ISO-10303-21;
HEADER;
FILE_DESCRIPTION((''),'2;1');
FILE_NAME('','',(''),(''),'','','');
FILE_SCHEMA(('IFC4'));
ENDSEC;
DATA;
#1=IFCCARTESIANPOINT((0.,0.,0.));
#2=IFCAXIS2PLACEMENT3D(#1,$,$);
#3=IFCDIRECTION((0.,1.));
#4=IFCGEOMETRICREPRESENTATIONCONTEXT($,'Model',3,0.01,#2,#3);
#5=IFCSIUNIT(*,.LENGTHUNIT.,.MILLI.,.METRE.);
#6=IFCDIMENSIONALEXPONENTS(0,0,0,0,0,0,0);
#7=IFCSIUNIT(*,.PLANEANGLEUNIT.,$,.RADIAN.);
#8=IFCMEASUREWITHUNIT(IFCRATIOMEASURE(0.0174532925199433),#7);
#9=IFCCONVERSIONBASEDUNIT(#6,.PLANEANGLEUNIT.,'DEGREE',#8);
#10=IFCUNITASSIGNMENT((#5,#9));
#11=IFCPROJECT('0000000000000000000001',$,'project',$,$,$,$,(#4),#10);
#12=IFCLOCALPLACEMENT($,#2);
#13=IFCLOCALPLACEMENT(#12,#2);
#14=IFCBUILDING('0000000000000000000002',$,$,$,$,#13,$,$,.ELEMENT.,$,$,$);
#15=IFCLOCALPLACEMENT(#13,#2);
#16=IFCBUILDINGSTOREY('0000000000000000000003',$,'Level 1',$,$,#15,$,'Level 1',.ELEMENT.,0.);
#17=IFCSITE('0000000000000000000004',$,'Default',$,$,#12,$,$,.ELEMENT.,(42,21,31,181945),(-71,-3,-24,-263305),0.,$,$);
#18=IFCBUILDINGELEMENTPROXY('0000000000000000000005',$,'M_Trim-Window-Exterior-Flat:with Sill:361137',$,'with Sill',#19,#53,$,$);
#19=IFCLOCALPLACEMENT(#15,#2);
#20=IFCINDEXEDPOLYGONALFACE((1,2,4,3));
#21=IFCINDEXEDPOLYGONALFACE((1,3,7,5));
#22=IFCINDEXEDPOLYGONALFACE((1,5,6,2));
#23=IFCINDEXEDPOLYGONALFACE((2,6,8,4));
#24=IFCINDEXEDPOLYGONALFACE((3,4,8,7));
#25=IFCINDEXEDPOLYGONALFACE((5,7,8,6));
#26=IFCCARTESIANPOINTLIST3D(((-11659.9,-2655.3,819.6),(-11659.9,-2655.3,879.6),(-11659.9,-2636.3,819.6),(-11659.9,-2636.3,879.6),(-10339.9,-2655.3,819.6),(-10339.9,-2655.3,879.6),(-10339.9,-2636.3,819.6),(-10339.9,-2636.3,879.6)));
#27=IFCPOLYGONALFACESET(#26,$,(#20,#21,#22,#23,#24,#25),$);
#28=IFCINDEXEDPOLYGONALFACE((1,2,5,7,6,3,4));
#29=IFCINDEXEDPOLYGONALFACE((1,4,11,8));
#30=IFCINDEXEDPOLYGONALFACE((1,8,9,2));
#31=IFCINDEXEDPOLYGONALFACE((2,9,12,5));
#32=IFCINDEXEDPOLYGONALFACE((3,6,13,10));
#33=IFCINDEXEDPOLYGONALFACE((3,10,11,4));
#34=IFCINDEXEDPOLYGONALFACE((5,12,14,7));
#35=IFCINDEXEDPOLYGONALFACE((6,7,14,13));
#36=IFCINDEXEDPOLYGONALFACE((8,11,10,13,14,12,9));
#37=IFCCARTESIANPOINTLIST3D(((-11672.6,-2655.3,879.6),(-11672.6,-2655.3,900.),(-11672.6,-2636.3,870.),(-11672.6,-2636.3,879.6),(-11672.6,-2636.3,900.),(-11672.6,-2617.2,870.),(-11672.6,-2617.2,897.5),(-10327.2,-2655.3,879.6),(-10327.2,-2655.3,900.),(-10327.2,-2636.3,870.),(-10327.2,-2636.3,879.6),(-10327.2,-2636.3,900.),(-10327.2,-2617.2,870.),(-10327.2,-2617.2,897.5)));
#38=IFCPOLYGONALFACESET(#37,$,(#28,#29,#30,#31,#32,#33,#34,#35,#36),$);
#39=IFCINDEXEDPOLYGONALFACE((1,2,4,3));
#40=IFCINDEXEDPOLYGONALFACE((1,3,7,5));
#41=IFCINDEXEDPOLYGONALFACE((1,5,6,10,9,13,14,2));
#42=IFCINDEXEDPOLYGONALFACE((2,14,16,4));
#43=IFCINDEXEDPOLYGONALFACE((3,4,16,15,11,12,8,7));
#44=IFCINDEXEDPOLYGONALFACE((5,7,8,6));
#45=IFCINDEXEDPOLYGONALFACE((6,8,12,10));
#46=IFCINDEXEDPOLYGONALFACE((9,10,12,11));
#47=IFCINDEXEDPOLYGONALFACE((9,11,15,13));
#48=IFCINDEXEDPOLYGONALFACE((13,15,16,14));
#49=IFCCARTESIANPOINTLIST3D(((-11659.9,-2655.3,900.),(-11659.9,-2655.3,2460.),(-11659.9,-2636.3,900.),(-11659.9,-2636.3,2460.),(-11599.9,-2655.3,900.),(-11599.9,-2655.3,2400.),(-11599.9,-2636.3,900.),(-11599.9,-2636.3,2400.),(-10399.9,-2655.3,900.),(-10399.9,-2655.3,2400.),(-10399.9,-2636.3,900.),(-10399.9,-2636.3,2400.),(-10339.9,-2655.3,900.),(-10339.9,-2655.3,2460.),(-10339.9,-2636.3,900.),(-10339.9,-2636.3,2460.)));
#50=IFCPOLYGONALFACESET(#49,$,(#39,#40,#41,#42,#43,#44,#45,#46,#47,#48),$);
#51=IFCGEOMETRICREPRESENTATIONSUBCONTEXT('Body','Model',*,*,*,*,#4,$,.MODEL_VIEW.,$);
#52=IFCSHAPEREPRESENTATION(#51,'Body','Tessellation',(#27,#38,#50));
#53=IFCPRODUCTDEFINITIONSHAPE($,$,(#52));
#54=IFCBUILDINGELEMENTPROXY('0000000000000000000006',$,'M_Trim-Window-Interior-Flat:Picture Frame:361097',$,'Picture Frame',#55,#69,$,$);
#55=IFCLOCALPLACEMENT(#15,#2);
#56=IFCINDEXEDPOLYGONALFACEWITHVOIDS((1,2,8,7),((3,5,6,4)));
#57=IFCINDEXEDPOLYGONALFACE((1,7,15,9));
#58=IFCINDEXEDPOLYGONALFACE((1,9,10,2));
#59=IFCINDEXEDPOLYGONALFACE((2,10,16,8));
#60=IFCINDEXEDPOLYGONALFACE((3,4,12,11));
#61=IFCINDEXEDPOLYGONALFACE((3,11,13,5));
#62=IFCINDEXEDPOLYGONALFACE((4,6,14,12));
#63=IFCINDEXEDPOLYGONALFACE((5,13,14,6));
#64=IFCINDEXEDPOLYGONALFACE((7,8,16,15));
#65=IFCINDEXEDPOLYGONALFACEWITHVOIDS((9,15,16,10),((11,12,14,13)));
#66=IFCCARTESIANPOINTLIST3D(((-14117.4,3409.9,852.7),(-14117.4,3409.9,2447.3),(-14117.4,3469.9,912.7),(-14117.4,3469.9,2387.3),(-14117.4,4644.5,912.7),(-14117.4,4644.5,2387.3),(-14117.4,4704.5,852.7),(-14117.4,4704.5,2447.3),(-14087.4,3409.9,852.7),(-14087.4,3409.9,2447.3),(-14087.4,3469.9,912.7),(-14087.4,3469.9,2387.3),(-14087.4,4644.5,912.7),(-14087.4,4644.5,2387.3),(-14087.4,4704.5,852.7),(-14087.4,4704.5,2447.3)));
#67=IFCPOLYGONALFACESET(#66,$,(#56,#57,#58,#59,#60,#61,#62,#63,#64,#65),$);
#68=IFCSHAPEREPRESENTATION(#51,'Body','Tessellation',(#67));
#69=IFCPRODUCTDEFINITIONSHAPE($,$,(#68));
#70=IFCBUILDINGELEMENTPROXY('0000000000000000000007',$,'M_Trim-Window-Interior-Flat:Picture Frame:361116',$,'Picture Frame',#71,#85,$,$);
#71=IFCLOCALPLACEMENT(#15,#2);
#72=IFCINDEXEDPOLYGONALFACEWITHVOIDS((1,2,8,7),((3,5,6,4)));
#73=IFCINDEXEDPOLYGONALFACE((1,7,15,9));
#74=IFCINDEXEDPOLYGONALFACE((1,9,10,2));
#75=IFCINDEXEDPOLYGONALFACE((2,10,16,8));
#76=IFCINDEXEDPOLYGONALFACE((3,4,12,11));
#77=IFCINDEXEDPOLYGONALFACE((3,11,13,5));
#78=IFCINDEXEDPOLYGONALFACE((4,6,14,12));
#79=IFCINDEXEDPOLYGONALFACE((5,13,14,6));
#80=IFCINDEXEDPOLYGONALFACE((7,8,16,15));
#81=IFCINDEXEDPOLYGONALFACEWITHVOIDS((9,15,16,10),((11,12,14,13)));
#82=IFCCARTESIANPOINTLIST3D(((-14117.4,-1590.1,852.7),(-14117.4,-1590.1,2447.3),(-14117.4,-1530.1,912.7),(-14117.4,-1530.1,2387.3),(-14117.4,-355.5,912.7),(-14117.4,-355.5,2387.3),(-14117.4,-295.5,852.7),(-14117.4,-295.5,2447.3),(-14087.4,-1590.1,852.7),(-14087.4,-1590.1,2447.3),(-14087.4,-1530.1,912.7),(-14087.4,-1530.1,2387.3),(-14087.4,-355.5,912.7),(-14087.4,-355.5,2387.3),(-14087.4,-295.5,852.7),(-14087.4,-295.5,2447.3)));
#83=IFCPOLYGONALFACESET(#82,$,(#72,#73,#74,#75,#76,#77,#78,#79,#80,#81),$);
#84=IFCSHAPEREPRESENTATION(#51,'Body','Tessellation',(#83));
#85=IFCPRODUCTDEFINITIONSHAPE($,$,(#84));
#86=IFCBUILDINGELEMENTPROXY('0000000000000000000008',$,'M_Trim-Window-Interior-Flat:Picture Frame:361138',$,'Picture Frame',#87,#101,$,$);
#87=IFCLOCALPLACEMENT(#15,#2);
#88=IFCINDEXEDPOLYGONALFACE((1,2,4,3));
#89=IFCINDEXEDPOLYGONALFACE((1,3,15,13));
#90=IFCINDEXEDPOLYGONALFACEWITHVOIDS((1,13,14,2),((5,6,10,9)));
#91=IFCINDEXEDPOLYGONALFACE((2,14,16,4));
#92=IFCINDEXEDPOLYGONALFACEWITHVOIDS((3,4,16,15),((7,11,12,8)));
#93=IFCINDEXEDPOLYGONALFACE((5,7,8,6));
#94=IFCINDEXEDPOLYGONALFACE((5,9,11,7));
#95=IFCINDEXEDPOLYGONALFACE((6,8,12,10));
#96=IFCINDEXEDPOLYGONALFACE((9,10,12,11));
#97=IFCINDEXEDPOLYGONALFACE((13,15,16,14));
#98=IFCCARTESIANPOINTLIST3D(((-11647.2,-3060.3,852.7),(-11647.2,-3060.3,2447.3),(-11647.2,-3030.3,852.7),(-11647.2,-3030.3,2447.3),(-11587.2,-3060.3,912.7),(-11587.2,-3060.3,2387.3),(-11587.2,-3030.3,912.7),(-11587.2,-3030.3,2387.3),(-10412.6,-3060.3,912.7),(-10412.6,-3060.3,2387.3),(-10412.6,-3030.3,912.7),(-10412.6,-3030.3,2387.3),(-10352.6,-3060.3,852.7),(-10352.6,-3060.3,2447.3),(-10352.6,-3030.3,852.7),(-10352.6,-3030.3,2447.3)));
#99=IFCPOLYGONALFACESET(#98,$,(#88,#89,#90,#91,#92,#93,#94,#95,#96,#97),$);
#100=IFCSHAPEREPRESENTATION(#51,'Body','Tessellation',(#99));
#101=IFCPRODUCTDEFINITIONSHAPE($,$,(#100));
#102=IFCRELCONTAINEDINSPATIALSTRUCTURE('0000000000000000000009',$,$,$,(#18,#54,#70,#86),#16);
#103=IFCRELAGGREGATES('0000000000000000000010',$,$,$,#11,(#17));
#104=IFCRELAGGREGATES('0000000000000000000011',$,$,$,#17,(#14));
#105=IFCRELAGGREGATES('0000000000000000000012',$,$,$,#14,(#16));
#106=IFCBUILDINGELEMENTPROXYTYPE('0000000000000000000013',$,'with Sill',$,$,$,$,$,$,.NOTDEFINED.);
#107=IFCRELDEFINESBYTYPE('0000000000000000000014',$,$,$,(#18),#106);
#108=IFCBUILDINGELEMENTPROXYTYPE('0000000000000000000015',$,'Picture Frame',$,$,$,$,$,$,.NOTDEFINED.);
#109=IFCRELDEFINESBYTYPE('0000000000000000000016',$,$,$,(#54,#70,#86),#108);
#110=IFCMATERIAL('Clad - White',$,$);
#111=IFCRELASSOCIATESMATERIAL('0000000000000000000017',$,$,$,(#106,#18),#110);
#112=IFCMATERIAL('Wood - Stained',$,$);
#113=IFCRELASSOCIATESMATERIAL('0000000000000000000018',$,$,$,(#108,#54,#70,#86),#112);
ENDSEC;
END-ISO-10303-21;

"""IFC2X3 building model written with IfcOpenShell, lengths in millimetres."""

from ifc_helpers import new_model, entity, si_unit, converted_unit, direction, frame, frame_2d, origin, place, context, subcontext, project, spatial, polyline, rectangle, outline, extrude, source, transform, mapped, material, type_object, type_shapes, element, save


model = new_model("IFC2X3")

# Units and contexts
model_context = context("Model", 3, precision=0.01, world=origin(), true_north=direction((0.0, 1.0)))
body_context = subcontext(model_context, "Body", "Model", "MODEL_VIEW")
ifc_project = project(units=[si_unit("LENGTHUNIT", "METRE", prefix="MILLI"), converted_unit("PLANEANGLEUNIT", "DEGREE", entity("IfcRatioMeasure", 0.0174532925199433), si_unit("PLANEANGLEUNIT", "RADIAN"), dimensions=[0, 0, 0, 0, 0, 0, 0])], contexts=[model_context])

# Site, building, storey
site_placement = place(None, origin())
site = spatial("IfcSite", under=ifc_project, at=site_placement, Name="Default", CompositionType="ELEMENT", RefLatitude=(42, 21, 31, 181945), RefLongitude=(-71, -3, -24, -263305), RefElevation=0.0)
building_placement = place(site_placement, origin())
building = spatial("IfcBuilding", under=site, at=building_placement, CompositionType="ELEMENT")
storey_placement = place(building_placement, origin())
storey = spatial("IfcBuildingStorey", under=building, at=storey_placement, Name="Level 1", LongName="Level 1", CompositionType="ELEMENT", Elevation=0.0)

# Building element proxies
ifc_material_1 = material(Name="Clad - White")
ifc_material_2 = material(Name="Wood - Stained")
building_element_proxy_type_1 = type_object("IfcBuildingElementProxyType", Name="with Sill", PredefinedType="NOTDEFINED", material=ifc_material_1)
shared_shape_1 = source(origin(), body_context, "Body", "SweptSolid", [
    extrude(rectangle(XDim=1320.0, YDim=60.0, at=frame_2d((0.0, 0.0), x_axis=(1.0, 0.0))), frame((0.0, -1550.4, 0.0), z_axis=(0.0, 0.0, 1.0), x_axis=(-1.0, 0.0, 0.0)), (0.0, 0.0, 1.0), 19.1),
    extrude(outline(polyline([(-19.0, -15.2), (0.0, -15.2), (0.0, -5.7), (19.0, -5.7), (19.0, 14.8), (0.0, 14.8), (-19.0, 12.3), (-19.0, -15.2)])), frame((-672.7, -1514.8, 19.0), z_axis=(1.0, 0.0, 0.0), x_axis=(0.0, 0.0, -1.0)), (0.0, 0.0, 1.0), 1345.4),
    extrude(outline(polyline([(-795.0, -660.0), (765.0, -660.0), (765.0, -600.0), (-735.0, -600.0), (-735.0, 600.0), (765.0, 600.0), (765.0, 660.0), (-795.0, 660.0), (-795.0, -660.0)])), frame((0.0, -735.0, 0.0), z_axis=(0.0, 0.0, 1.0), x_axis=(0.0, -1.0, 0.0)), (0.0, 0.0, 1.0), 19.1),
])
type_shapes(building_element_proxy_type_1, [shared_shape_1])
for number, where, z_axis, x_axis, name in (
    (1, (-10999.9, -2655.3, 2400.0), (0.0, 1.0, 0.0), (-1.0, 0.0, 0.0), "M_Trim-Window-Exterior-Flat:with Sill:361137"),
):
    element("IfcBuildingElementProxy", number, at=place(storey_placement, frame(where, z_axis=z_axis, x_axis=x_axis)), inside=storey, type_object=building_element_proxy_type_1, material=ifc_material_1, Name=name, ObjectType="with Sill", context=body_context, shape_type="MappedRepresentation", body=[
        mapped(shared_shape_1, transform((0.0, 0.0, 0.0), scale=1.0)),
    ])
building_element_proxy_type_2 = type_object("IfcBuildingElementProxyType", Name="Picture Frame", PredefinedType="NOTDEFINED", material=ifc_material_2)
shared_shape_2 = source(origin(), body_context, "Body", "SweptSolid", [
    extrude(outline(polyline([(-647.3, -797.3), (647.3, -797.3), (647.3, 797.3), (-647.3, 797.3), (-647.3, -797.3)]), holes=[polyline([(-587.3, -737.3), (-587.3, 737.3), (587.3, 737.3), (587.3, -737.3), (-587.3, -737.3)])]), frame((0.0, -750.0, 0.0), z_axis=(0.0, 0.0, 1.0), x_axis=(-1.0, 0.0, 0.0)), (0.0, 0.0, 1.0), 30.0),
])
type_shapes(building_element_proxy_type_2, [shared_shape_2])
for number, where, z_axis, x_axis, name in (
    (2, (-14087.4, 4057.2, 2400.0), (-1.0, 0.0, 0.0), (0.0, -1.0, 0.0), "M_Trim-Window-Interior-Flat:Picture Frame:361097"),
    (3, (-14087.4, -942.8, 2400.0), (-1.0, 0.0, 0.0), (0.0, -1.0, 0.0), "M_Trim-Window-Interior-Flat:Picture Frame:361116"),
    (4, (-10999.9, -3030.3, 2400.0), (0.0, -1.0, 0.0), (1.0, 0.0, 0.0), "M_Trim-Window-Interior-Flat:Picture Frame:361138"),
):
    element("IfcBuildingElementProxy", number, at=place(storey_placement, frame(where, z_axis=z_axis, x_axis=x_axis)), inside=storey, type_object=building_element_proxy_type_2, material=ifc_material_2, Name=name, ObjectType="Picture Frame", context=body_context, shape_type="MappedRepresentation", body=[
        mapped(shared_shape_2, transform((0.0, 0.0, 0.0), scale=1.0)),
    ])

save(model, "model.ifc")
